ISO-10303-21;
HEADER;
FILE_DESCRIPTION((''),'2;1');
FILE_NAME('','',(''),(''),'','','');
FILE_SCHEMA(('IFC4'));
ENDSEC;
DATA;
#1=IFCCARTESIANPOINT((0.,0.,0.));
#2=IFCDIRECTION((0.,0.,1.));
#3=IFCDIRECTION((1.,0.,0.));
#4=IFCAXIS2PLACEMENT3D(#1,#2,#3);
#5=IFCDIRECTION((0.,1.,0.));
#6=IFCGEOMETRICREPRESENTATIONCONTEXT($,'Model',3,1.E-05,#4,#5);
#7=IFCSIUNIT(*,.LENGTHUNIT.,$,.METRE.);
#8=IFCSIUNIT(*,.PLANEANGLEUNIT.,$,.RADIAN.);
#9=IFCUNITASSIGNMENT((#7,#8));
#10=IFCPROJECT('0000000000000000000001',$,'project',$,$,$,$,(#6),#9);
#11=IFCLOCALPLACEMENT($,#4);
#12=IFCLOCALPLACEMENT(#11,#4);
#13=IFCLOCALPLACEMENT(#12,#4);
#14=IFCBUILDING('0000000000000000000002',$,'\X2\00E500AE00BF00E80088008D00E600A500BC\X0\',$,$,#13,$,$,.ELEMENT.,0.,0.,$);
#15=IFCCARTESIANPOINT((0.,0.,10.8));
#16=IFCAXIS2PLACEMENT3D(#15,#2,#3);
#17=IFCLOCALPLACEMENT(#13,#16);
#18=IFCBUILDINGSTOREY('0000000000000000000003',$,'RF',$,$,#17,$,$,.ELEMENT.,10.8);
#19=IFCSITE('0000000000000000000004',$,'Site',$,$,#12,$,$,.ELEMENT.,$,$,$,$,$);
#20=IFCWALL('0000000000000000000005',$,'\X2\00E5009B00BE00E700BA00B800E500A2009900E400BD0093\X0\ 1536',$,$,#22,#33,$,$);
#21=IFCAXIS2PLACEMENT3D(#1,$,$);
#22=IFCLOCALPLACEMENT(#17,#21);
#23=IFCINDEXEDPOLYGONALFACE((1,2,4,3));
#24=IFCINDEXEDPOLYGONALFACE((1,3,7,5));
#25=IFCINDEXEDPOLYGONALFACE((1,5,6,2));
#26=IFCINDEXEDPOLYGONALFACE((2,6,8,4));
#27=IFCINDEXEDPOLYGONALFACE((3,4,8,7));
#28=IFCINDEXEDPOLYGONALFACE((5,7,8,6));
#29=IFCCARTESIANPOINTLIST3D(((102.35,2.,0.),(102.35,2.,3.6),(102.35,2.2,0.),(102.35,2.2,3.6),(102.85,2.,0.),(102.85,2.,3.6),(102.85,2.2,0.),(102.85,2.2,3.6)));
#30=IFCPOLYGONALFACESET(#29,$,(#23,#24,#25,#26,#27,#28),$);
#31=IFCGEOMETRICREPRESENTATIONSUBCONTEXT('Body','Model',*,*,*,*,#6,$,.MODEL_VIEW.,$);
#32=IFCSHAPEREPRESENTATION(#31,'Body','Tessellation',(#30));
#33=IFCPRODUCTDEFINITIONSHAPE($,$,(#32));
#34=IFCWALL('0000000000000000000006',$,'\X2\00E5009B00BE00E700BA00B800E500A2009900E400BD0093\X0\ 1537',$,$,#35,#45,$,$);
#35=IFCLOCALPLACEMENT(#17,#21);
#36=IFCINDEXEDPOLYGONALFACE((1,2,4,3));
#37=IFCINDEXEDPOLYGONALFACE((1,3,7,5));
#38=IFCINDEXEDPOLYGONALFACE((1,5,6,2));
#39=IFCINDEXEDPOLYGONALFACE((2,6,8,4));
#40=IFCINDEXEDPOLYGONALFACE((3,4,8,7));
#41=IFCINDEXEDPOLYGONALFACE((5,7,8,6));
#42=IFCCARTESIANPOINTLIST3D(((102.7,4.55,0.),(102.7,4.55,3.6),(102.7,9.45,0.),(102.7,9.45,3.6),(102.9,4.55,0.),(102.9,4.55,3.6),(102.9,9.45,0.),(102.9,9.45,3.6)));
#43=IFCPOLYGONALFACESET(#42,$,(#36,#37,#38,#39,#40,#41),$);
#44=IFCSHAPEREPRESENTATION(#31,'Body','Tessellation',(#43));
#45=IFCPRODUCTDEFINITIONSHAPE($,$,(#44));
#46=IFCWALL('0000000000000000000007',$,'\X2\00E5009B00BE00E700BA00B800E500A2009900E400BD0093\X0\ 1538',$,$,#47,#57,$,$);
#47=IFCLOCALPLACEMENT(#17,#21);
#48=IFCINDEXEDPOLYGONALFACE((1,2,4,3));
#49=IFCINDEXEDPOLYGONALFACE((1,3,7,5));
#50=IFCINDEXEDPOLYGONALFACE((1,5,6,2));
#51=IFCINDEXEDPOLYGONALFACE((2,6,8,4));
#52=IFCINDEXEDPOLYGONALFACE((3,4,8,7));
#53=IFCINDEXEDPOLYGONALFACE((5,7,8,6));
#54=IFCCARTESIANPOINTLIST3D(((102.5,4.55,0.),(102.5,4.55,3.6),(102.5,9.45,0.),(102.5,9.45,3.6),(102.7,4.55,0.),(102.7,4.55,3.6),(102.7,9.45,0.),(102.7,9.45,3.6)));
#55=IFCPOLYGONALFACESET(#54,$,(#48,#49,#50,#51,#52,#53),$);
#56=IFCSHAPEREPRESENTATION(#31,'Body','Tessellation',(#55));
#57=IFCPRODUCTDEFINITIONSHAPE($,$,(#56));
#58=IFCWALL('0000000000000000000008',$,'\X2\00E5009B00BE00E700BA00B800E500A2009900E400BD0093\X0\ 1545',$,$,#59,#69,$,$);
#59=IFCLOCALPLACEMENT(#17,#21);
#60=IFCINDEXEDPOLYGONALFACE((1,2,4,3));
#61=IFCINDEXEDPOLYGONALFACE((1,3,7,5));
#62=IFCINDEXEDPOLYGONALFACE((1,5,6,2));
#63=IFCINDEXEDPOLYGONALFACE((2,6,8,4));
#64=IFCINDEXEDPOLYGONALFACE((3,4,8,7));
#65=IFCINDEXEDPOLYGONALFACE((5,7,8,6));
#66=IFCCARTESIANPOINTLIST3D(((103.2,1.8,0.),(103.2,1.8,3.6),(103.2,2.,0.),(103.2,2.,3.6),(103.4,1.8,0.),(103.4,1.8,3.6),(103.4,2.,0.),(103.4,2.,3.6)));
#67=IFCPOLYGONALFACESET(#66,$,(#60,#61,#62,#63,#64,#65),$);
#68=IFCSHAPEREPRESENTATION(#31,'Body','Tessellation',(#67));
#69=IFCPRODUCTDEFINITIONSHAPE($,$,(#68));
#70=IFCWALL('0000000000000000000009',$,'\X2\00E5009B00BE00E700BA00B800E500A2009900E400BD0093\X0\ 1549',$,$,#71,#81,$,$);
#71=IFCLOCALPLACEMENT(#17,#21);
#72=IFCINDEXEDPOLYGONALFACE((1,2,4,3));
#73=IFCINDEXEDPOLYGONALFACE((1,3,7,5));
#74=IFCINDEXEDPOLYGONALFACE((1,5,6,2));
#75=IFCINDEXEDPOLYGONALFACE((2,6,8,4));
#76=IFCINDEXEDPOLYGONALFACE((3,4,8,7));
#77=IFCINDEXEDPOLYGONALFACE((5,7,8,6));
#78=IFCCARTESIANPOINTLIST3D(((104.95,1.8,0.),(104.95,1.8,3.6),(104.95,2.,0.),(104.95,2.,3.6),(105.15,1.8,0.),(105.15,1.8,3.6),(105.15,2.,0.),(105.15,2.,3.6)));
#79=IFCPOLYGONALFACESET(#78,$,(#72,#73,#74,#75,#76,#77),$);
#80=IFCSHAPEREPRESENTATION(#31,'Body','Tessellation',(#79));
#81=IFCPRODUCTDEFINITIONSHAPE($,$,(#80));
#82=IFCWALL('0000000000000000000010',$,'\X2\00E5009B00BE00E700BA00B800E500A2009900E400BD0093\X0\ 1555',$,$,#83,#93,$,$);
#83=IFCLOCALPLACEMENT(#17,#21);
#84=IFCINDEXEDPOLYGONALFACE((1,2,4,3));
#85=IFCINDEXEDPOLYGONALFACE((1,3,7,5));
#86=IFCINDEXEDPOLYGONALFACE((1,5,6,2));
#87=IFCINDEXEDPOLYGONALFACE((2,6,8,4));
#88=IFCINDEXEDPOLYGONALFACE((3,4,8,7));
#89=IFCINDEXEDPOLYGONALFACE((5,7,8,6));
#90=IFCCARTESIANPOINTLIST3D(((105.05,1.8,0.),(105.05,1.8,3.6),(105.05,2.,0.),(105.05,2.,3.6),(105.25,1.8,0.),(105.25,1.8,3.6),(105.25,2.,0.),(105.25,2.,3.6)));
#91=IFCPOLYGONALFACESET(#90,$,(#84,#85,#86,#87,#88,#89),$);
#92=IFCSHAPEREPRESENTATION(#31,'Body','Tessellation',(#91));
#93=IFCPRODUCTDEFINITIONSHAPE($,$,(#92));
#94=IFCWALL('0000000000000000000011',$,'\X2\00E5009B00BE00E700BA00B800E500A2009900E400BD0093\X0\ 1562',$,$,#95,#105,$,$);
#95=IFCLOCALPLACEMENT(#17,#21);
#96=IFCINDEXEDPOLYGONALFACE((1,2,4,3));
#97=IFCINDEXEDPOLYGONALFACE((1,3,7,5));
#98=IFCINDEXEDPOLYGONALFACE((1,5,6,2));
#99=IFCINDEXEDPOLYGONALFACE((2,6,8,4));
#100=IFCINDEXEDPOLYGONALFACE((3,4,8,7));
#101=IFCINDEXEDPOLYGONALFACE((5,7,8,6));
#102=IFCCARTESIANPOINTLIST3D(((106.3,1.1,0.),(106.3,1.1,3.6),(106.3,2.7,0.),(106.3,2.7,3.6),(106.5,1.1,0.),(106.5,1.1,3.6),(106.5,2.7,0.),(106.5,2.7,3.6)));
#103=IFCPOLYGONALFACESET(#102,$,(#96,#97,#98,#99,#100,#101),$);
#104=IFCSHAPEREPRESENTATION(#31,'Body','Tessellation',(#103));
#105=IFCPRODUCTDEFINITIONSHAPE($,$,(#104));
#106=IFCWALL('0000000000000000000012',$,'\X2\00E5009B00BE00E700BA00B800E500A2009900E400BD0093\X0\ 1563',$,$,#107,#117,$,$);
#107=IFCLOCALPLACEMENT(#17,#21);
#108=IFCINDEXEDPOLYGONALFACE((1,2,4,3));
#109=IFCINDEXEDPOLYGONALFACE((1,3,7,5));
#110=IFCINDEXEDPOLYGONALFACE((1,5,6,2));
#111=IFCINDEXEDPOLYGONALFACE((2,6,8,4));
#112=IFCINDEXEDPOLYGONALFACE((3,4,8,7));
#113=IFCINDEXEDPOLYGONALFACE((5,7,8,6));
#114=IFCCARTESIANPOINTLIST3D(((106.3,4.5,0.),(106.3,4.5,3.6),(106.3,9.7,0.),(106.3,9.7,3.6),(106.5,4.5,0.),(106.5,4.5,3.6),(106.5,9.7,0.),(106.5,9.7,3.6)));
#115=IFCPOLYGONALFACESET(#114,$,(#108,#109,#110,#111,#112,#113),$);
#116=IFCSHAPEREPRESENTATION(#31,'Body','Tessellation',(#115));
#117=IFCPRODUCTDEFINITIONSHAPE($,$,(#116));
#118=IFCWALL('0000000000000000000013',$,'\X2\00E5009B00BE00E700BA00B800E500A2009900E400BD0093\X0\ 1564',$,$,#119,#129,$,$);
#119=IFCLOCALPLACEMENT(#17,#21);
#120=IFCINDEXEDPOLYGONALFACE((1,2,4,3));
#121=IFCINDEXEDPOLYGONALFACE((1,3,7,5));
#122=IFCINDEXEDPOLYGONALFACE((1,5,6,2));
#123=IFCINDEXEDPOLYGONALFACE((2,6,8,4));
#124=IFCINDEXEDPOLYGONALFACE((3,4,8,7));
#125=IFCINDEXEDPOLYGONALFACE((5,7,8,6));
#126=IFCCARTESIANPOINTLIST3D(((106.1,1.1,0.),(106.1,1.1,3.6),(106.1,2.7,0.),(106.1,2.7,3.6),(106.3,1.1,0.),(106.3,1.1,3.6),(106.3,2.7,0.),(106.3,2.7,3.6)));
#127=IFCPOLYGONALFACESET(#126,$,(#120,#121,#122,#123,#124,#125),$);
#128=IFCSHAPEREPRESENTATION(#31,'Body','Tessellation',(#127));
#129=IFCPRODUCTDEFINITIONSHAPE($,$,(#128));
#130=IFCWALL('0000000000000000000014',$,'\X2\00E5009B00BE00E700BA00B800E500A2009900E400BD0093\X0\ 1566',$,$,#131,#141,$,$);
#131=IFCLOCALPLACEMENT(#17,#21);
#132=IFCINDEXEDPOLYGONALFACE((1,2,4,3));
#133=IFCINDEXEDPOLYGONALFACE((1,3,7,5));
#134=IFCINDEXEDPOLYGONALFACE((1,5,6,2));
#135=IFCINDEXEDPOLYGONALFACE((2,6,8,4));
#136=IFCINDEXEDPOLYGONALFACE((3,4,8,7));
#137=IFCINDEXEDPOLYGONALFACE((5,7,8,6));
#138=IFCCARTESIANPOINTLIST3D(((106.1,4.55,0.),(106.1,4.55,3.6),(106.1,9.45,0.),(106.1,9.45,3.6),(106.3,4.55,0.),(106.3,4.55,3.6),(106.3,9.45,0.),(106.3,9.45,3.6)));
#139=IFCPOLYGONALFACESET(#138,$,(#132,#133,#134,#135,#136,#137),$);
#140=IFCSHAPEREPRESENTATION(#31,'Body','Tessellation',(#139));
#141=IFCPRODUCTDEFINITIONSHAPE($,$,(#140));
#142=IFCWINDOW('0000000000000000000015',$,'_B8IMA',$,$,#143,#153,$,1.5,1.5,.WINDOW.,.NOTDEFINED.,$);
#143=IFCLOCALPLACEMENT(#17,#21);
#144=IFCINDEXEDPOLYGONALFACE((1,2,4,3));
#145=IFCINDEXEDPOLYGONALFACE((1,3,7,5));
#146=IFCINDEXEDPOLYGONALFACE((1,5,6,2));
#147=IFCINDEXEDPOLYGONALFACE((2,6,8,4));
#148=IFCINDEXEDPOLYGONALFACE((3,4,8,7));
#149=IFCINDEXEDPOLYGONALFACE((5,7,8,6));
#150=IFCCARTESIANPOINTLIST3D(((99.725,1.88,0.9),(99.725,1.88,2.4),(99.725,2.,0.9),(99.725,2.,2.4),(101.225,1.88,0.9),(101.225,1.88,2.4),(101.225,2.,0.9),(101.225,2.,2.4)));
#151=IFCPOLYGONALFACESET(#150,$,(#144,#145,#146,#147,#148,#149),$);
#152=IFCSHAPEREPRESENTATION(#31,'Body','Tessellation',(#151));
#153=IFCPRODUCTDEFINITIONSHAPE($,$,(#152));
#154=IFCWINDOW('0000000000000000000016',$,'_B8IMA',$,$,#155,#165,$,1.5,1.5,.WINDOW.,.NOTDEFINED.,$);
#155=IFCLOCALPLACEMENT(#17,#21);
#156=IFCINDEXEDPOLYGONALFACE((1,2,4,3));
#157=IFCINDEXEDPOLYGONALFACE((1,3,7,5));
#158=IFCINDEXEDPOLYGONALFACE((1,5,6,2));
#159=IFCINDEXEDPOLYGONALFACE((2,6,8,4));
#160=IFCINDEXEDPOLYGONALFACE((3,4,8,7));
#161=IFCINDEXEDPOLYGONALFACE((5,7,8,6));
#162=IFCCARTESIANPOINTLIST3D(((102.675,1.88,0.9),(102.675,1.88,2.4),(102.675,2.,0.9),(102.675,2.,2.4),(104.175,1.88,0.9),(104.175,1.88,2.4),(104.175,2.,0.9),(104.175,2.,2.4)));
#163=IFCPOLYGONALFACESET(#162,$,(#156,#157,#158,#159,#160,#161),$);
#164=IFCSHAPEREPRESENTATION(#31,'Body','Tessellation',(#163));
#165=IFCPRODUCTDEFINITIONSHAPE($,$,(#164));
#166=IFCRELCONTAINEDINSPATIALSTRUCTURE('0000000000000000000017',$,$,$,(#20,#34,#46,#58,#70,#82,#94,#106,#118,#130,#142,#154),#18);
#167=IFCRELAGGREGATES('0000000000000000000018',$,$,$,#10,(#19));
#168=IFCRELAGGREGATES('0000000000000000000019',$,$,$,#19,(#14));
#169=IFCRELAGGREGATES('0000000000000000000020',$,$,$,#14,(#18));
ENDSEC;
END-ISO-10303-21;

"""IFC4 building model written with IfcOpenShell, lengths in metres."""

from ifc_helpers import new_model, si_unit, direction, frame, frame_2d, origin_with_axes, place, context, subcontext, project, spatial, rectangle, extrude, element, save


model = new_model("IFC4")

# Units and contexts
model_context = context("Model", 3, precision=1e-05, world=origin_with_axes(), true_north=direction((0.0, 1.0, 0.0)))
body_context = subcontext(model_context, "Body", "Model", "MODEL_VIEW")
ifc_project = project(units=[si_unit("LENGTHUNIT", "METRE"), si_unit("PLANEANGLEUNIT", "RADIAN")], contexts=[model_context])

# Site, building, storey
placement = place(None, origin_with_axes())
site_placement = place(placement, origin_with_axes())
site = spatial("IfcSite", under=ifc_project, at=site_placement, Name="Site", CompositionType="ELEMENT")
building_placement = place(site_placement, origin_with_axes())
building = spatial("IfcBuilding", under=site, at=building_placement, Name="å®¿è\u0088\u008dæ¥¼", CompositionType="ELEMENT", ElevationOfRefHeight=0.0, ElevationOfTerrain=0.0)
storey_placement = place(building_placement, frame((0.0, 0.0, 10.8), z_axis=(0.0, 0.0, 1.0), x_axis=(1.0, 0.0, 0.0)))
storey = spatial("IfcBuildingStorey", under=building, at=storey_placement, Name="RF", CompositionType="ELEMENT", Elevation=10.8)

# Walls
for number, where, z_axis, x_axis, name in (
    (1, (102.6, 2.1, 0.0), (0.0, 0.0, 1.0), (-1.0, 0.0, 0.0), "å\u009b¾çº¸å¢\u0099ä½\u0093 1536"),
):
    element("IfcWall", number, at=place(storey_placement, frame(where, z_axis=z_axis, x_axis=x_axis)), inside=storey, Name=name, context=body_context, shape_type="SweptSolid", body=[
        extrude(rectangle(XDim=0.5, YDim=0.2, at=frame_2d((0.0, 0.0), x_axis=(1.0, 0.0, 0.0))), frame((0.0, 0.0, 0.0), z_axis=(0.0, 0.0, 1.0)), (0.0, 0.0, 1.0), 3.6),
    ])
for number, where, z_axis, x_axis, name in (
    (2, (102.8, 7.0, 0.0), (0.0, 0.0, 1.0), (0.0, -1.0, 0.0), "å\u009b¾çº¸å¢\u0099ä½\u0093 1537"),
    (3, (102.6, 7.0, 0.0), (0.0, 0.0, 1.0), (0.0, -1.0, 0.0), "å\u009b¾çº¸å¢\u0099ä½\u0093 1538"),
):
    element("IfcWall", number, at=place(storey_placement, frame(where, z_axis=z_axis, x_axis=x_axis)), inside=storey, Name=name, context=body_context, shape_type="SweptSolid", body=[
        extrude(rectangle(XDim=4.9, YDim=0.2, at=frame_2d((0.0, 0.0), x_axis=(1.0, 0.0, 0.0))), frame((0.0, 0.0, 0.0), z_axis=(0.0, 0.0, 1.0)), (0.0, 0.0, 1.0), 3.6),
    ])
for number, where, z_axis, x_axis, name in (
    (4, (103.3, 1.9, 0.0), (0.0, 0.0, 1.0), (0.0, 1.0, 0.0), "å\u009b¾çº¸å¢\u0099ä½\u0093 1545"),
    (5, (105.05, 1.9, 0.0), (0.0, 0.0, 1.0), (0.0, 1.0, 0.0), "å\u009b¾çº¸å¢\u0099ä½\u0093 1549"),
    (6, (105.15, 1.9, 0.0), (0.0, 0.0, 1.0), (0.0, -1.0, 0.0), "å\u009b¾çº¸å¢\u0099ä½\u0093 1555"),
):
    element("IfcWall", number, at=place(storey_placement, frame(where, z_axis=z_axis, x_axis=x_axis)), inside=storey, Name=name, context=body_context, shape_type="SweptSolid", body=[
        extrude(rectangle(XDim=0.2, YDim=0.2, at=frame_2d((0.0, 0.0), x_axis=(1.0, 0.0, 0.0))), frame((0.0, 0.0, 0.0), z_axis=(0.0, 0.0, 1.0)), (0.0, 0.0, 1.0), 3.6),
    ])
wall_1_placement = place(storey_placement, frame((106.4, 1.9, 0.0), z_axis=(0.0, 0.0, 1.0), x_axis=(0.0, -1.0, 0.0)))
element("IfcWall", 7, at=wall_1_placement, inside=storey, Name="å\u009b¾çº¸å¢\u0099ä½\u0093 1562", context=body_context, shape_type="SweptSolid", body=[
    extrude(rectangle(XDim=1.6, YDim=0.2, at=frame_2d((0.0, 0.0), x_axis=(1.0, 0.0, 0.0))), frame((0.0, 0.0, 0.0), z_axis=(0.0, 0.0, 1.0)), (0.0, 0.0, 1.0), 3.6),
])
wall_2_placement = place(storey_placement, frame((106.4, 7.1, 0.0), z_axis=(0.0, 0.0, 1.0), x_axis=(0.0, -1.0, 0.0)))
element("IfcWall", 8, at=wall_2_placement, inside=storey, Name="å\u009b¾çº¸å¢\u0099ä½\u0093 1563", context=body_context, shape_type="SweptSolid", body=[
    extrude(rectangle(XDim=5.2, YDim=0.2, at=frame_2d((0.0, 0.0), x_axis=(1.0, 0.0, 0.0))), frame((0.0, 0.0, 0.0), z_axis=(0.0, 0.0, 1.0)), (0.0, 0.0, 1.0), 3.6),
])
wall_3_placement = place(storey_placement, frame((106.2, 1.9, 0.0), z_axis=(0.0, 0.0, 1.0), x_axis=(0.0, -1.0, 0.0)))
element("IfcWall", 9, at=wall_3_placement, inside=storey, Name="å\u009b¾çº¸å¢\u0099ä½\u0093 1564", context=body_context, shape_type="SweptSolid", body=[
    extrude(rectangle(XDim=1.6, YDim=0.2, at=frame_2d((0.0, 0.0), x_axis=(1.0, 0.0, 0.0))), frame((0.0, 0.0, 0.0), z_axis=(0.0, 0.0, 1.0)), (0.0, 0.0, 1.0), 3.6),
])
wall_4_placement = place(storey_placement, frame((106.2, 7.0, 0.0), z_axis=(0.0, 0.0, 1.0), x_axis=(0.0, -1.0, 0.0)))
element("IfcWall", 10, at=wall_4_placement, inside=storey, Name="å\u009b¾çº¸å¢\u0099ä½\u0093 1566", context=body_context, shape_type="SweptSolid", body=[
    extrude(rectangle(XDim=4.9, YDim=0.2, at=frame_2d((0.0, 0.0), x_axis=(1.0, 0.0, 0.0))), frame((0.0, 0.0, 0.0), z_axis=(0.0, 0.0, 1.0)), (0.0, 0.0, 1.0), 3.6),
])

# Windows
for number, where, z_axis, x_axis, name in (
    (11, (100.475, 1.94, 0.9), (0.0, 0.0, 1.0), (1.0, 0.0, 0.0), "_B8IMA"),
    (12, (103.425, 1.94, 0.9), (0.0, 0.0, 1.0), (1.0, 0.0, 0.0), "_B8IMA"),
):
    element("IfcWindow", number, at=place(storey_placement, frame(where, z_axis=z_axis, x_axis=x_axis)), inside=storey, Name=name, OverallHeight=1.5, OverallWidth=1.5, PartitioningType="NOTDEFINED", PredefinedType="WINDOW", context=body_context, shape_type="SweptSolid", body=[
        extrude(rectangle(XDim=1.5, YDim=0.12, at=frame_2d((0.0, 0.0), x_axis=(1.0, 0.0, 0.0))), frame((0.0, 0.0, 0.0), z_axis=(0.0, 0.0, 1.0)), (0.0, 0.0, 1.0), 1.5),
    ])

save(model, "model.ifc")
